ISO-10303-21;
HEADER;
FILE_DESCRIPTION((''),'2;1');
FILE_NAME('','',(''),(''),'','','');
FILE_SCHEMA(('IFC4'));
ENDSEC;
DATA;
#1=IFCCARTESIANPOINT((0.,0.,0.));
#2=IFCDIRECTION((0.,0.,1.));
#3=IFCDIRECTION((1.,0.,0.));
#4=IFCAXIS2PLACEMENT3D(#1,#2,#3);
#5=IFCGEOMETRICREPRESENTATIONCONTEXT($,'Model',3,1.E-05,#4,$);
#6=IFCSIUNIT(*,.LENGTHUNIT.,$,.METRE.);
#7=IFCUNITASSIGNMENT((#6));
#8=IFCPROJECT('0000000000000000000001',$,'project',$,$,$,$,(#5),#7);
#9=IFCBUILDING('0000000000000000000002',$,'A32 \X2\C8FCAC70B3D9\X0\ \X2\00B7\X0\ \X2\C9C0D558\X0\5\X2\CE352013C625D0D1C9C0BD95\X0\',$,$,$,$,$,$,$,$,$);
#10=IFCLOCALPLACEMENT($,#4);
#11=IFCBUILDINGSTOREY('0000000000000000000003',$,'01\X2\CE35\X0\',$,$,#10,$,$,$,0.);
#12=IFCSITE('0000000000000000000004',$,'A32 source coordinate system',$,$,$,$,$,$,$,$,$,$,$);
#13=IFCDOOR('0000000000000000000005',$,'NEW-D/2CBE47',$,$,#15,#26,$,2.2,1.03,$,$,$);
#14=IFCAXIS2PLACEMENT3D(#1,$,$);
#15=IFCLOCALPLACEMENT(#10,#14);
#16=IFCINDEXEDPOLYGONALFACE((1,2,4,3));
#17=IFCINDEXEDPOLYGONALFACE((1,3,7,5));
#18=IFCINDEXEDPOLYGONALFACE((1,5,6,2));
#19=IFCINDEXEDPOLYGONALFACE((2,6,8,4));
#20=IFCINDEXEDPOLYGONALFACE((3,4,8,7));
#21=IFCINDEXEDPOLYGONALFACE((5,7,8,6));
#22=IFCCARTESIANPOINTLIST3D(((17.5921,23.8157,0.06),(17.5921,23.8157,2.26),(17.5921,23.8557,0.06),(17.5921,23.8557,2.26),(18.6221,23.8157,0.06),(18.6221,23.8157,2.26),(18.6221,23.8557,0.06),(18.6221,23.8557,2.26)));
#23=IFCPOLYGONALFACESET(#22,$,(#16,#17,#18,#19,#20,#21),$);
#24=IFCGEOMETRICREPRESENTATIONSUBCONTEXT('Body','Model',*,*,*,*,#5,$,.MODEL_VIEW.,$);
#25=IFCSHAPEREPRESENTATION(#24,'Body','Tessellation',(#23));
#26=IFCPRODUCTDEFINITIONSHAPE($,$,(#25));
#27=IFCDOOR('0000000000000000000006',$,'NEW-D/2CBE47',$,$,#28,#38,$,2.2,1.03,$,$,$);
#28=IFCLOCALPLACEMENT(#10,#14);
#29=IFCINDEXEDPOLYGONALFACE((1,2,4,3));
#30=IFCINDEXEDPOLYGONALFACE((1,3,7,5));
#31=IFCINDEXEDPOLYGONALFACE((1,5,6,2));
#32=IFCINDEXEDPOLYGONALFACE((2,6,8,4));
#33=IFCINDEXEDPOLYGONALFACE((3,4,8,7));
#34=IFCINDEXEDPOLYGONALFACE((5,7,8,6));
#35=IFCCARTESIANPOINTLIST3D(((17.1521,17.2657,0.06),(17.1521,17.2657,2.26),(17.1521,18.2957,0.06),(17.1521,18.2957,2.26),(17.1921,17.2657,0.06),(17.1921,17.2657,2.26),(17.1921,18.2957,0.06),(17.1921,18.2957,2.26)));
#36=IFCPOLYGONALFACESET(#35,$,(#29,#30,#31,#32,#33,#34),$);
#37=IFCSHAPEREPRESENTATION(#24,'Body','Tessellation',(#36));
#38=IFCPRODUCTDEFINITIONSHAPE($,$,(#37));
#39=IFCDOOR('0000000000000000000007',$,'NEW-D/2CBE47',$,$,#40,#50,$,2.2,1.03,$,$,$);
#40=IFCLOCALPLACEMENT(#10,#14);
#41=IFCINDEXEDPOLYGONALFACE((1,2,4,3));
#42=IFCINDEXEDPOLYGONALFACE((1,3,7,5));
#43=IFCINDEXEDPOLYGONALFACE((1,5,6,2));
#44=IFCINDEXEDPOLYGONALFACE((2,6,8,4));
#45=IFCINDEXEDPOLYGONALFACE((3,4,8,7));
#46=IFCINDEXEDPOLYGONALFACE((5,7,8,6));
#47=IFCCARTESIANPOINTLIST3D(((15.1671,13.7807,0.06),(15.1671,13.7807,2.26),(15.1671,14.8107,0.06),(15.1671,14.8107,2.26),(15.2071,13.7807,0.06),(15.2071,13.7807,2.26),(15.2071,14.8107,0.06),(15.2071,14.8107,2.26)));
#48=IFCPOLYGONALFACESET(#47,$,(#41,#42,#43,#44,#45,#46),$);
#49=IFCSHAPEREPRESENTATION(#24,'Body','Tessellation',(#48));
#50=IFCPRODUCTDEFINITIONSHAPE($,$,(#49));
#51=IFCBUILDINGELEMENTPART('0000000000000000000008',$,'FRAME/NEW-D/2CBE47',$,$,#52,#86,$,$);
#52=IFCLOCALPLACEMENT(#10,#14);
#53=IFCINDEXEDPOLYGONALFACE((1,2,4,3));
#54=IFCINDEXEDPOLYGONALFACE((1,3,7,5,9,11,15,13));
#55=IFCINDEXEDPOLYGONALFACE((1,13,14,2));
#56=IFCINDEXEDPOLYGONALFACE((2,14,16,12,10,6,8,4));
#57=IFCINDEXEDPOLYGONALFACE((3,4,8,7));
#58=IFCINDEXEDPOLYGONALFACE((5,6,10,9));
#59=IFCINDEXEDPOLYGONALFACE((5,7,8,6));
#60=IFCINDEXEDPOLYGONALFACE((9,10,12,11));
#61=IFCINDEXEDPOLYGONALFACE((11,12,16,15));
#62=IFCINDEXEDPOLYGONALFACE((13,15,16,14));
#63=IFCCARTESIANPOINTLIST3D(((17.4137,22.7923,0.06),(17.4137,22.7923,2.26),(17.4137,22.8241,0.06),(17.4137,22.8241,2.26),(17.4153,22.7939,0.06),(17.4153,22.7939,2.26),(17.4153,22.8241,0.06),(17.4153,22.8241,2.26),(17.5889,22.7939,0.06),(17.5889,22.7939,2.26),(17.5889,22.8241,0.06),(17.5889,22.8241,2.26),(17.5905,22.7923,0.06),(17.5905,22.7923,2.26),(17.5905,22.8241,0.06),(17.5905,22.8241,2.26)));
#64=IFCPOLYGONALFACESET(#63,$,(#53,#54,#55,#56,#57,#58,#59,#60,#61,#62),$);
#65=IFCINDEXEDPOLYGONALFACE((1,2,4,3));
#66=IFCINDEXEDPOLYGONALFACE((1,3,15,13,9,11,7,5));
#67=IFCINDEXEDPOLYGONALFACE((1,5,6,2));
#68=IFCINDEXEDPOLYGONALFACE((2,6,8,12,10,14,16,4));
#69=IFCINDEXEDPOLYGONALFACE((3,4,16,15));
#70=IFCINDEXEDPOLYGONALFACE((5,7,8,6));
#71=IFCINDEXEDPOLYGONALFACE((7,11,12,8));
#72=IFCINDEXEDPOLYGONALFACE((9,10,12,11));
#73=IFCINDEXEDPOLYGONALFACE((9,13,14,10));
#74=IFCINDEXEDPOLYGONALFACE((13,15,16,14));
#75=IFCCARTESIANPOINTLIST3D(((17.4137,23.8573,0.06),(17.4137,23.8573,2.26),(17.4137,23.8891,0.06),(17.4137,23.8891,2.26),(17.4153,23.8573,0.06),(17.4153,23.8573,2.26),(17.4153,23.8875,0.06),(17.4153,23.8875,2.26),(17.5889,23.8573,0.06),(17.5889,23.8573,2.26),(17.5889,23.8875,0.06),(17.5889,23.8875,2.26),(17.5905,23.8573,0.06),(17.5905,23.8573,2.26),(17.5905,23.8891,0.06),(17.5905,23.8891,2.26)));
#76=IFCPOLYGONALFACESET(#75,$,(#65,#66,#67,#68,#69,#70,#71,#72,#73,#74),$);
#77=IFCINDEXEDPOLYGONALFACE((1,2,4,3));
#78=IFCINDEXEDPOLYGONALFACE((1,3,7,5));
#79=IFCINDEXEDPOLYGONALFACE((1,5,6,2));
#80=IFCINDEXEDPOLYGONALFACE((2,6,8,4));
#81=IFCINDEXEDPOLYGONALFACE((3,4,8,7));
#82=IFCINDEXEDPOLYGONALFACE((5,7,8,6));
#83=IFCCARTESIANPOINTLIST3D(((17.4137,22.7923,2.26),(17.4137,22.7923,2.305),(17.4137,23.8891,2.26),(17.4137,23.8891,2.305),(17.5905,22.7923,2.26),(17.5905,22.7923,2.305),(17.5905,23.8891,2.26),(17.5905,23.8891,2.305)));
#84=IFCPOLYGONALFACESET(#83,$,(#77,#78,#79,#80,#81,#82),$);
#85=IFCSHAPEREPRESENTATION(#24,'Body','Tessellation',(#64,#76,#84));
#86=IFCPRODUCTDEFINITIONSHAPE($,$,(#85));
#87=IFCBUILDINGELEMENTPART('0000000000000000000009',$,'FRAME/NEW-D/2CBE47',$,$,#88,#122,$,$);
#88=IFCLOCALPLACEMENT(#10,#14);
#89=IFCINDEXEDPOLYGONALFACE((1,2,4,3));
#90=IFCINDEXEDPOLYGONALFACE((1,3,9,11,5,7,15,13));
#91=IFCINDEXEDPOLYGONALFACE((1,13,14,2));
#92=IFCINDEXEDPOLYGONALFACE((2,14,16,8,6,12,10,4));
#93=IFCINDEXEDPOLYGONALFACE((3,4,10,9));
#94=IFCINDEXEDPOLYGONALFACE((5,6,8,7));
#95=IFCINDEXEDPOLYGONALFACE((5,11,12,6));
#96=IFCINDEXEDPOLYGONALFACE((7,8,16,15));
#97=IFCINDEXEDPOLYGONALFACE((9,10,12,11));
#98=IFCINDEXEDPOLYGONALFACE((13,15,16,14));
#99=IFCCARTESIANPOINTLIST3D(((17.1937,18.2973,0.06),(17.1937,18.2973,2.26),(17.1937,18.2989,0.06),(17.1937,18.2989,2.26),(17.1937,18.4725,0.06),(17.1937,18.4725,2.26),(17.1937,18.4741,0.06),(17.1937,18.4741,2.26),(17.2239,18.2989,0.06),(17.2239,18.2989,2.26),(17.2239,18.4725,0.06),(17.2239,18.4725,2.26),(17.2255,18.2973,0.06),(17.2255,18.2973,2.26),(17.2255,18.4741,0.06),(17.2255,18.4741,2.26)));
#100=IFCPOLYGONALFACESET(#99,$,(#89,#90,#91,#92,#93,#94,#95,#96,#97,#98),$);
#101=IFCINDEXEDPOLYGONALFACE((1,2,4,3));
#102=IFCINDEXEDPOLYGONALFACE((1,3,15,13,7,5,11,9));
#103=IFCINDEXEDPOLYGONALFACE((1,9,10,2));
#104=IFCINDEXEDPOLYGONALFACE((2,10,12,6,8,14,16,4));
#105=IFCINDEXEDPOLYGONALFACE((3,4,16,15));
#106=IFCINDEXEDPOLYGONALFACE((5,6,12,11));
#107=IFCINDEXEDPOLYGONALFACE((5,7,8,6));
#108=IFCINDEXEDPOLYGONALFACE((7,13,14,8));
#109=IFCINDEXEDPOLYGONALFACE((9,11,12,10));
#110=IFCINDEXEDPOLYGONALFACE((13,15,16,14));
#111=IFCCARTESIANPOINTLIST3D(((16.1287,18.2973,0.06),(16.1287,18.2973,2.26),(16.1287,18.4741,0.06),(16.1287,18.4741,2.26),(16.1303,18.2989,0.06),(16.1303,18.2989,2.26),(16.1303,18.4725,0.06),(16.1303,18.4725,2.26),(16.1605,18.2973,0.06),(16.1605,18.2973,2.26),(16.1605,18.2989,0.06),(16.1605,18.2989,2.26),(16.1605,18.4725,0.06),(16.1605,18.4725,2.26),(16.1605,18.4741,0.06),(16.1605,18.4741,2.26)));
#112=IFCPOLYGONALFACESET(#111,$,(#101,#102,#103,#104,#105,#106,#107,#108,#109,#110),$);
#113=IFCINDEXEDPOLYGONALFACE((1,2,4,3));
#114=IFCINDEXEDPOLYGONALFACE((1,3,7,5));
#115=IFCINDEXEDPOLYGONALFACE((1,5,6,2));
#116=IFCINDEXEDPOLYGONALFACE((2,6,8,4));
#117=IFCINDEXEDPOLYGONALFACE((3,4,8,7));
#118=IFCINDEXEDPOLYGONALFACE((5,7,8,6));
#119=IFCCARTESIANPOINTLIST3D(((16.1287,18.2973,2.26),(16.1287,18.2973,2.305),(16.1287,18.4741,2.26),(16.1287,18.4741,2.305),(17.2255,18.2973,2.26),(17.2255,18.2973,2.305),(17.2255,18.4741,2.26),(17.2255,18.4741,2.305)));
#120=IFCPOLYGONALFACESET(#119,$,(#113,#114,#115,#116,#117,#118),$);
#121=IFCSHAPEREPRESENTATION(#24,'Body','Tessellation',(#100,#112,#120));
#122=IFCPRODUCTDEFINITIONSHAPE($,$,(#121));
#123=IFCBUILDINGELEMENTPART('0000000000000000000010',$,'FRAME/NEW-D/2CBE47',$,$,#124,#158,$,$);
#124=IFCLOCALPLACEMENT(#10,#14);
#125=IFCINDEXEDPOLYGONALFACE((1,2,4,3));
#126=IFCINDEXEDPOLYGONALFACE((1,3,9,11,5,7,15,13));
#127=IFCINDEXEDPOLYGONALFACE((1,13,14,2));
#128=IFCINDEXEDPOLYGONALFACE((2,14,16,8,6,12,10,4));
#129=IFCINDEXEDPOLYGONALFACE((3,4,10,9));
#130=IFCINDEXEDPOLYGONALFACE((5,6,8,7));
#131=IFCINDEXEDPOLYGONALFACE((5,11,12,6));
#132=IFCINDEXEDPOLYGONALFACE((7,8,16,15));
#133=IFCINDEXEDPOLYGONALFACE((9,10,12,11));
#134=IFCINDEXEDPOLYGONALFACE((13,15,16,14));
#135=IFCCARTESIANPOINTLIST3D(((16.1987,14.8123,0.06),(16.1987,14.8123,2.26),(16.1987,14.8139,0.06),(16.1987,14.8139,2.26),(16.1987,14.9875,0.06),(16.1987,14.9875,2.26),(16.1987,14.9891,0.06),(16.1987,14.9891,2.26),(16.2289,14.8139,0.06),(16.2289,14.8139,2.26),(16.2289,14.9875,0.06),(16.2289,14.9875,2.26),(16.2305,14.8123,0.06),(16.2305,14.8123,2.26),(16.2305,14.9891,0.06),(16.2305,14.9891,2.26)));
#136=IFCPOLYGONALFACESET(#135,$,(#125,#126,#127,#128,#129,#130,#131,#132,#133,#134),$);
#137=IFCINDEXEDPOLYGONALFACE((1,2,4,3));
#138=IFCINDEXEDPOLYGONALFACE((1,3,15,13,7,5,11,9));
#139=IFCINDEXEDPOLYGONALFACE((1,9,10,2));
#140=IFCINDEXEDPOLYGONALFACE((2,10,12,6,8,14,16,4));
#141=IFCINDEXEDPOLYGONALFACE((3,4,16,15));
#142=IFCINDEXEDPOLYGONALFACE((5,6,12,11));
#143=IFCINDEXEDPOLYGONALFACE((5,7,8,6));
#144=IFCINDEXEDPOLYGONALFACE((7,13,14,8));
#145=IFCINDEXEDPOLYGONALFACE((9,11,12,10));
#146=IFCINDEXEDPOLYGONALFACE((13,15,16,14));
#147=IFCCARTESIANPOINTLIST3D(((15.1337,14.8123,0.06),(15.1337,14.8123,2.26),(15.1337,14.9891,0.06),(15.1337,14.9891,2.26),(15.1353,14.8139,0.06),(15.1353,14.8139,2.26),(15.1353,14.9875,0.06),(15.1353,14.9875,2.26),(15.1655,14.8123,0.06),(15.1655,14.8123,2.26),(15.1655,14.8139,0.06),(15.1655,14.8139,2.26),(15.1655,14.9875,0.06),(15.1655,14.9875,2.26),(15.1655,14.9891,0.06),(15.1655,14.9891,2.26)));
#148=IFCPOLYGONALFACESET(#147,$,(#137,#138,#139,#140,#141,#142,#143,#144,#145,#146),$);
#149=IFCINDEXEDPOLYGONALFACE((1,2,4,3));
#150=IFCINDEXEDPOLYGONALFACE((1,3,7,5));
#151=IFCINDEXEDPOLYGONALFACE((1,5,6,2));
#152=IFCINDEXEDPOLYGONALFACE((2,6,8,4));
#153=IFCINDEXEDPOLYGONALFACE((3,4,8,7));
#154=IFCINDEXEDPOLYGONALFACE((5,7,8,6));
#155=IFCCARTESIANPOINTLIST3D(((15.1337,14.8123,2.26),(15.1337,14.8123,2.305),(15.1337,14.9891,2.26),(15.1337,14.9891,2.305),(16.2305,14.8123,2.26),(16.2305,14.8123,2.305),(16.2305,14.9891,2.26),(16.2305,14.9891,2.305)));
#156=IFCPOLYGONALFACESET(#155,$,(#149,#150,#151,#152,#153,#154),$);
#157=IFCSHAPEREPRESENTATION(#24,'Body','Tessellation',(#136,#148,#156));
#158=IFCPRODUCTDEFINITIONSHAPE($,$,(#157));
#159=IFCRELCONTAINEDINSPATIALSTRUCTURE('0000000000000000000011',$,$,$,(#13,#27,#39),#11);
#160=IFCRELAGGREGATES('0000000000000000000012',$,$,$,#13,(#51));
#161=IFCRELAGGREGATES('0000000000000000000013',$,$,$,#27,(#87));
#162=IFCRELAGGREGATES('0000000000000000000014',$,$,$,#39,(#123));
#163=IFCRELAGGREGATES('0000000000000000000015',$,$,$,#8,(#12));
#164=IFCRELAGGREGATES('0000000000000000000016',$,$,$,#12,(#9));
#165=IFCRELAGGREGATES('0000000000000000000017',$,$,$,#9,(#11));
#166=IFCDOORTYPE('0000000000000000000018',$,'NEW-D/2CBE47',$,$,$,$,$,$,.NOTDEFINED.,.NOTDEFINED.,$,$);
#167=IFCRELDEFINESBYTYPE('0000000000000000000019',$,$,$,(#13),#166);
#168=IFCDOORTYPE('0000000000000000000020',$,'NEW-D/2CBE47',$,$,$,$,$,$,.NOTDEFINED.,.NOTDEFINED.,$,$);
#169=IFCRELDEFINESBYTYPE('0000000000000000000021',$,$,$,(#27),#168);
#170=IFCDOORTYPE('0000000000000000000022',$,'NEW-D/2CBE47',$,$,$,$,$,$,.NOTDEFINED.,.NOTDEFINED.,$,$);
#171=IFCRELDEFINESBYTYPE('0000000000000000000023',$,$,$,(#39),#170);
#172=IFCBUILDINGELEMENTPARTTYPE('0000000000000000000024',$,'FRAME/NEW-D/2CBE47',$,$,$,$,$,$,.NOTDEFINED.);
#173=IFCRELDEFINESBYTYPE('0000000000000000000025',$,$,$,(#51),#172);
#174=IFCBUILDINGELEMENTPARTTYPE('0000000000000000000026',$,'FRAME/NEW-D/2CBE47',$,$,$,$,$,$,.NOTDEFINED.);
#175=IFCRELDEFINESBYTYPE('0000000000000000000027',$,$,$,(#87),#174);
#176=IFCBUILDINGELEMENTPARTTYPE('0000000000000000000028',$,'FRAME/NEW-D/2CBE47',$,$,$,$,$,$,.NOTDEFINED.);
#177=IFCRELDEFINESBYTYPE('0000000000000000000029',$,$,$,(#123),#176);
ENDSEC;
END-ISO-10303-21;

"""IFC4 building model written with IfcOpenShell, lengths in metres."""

from ifc_helpers import new_model, si_unit, frame, origin, origin_with_axes, place, context, subcontext, project, spatial, polyline, outline, extrude, source, transform, mapped, type_object, type_shapes, element, aggregate, save


model = new_model("IFC4")

# Units and contexts
model_context = context("Model", 3, precision=1e-05, world=origin_with_axes())
body_context = subcontext(model_context, "Body", "Model", "MODEL_VIEW")
ifc_project = project(units=[si_unit("LENGTHUNIT", "METRE")], contexts=[model_context])

# Site, building, storey
site = spatial("IfcSite", under=ifc_project, Name="A32 source coordinate system")
building = spatial("IfcBuilding", under=site, Name="A32 주거동 · 지하5층–옥탑지붕")
storey_placement = place(None, origin_with_axes())
storey = spatial("IfcBuildingStorey", under=building, at=storey_placement, Name="01층", Elevation=0.0)

# Doors
door_type_1 = type_object("IfcDoorType", Name="NEW-D/2CBE47", OperationType="NOTDEFINED", PredefinedType="NOTDEFINED")
shared_shape_1 = source(origin(), body_context, "Body", "SweptSolid", [
    extrude(outline(polyline([(18.6221, 23.8157), (17.5921, 23.8157), (17.5921, 23.8557), (18.6221, 23.8557), (18.6221, 23.8157)])), frame((0.0, 0.0, 0.06)), (0.0, 0.0, 1.0), 2.2),
])
type_shapes(door_type_1, [shared_shape_1])
door_1_placement = place(storey_placement, origin_with_axes())
door_1 = element("IfcDoor", 1, at=door_1_placement, inside=storey, type_object=door_type_1, Name="NEW-D/2CBE47", OverallHeight=2.2, OverallWidth=1.03, context=body_context, shape_type="MappedRepresentation", body=[
    mapped(shared_shape_1, transform((0.0, 0.0, 0.0), scale=1.0)),
])
door_type_2 = type_object("IfcDoorType", Name="NEW-D/2CBE47", OperationType="NOTDEFINED", PredefinedType="NOTDEFINED")
shared_shape_2 = source(origin(), body_context, "Body", "SweptSolid", [
    extrude(outline(polyline([(17.1521, 17.2657), (17.1521, 18.2957), (17.1921, 18.2957), (17.1921, 17.2657), (17.1521, 17.2657)])), frame((0.0, 0.0, 0.06)), (0.0, 0.0, 1.0), 2.2),
])
type_shapes(door_type_2, [shared_shape_2])
door_2_placement = place(storey_placement, origin_with_axes())
door_2 = element("IfcDoor", 2, at=door_2_placement, inside=storey, type_object=door_type_2, Name="NEW-D/2CBE47", OverallHeight=2.2, OverallWidth=1.03, context=body_context, shape_type="MappedRepresentation", body=[
    mapped(shared_shape_2, transform((0.0, 0.0, 0.0), scale=1.0)),
])
door_type_3 = type_object("IfcDoorType", Name="NEW-D/2CBE47", OperationType="NOTDEFINED", PredefinedType="NOTDEFINED")
shared_shape_3 = source(origin(), body_context, "Body", "SweptSolid", [
    extrude(outline(polyline([(15.1671, 14.8107), (15.2071, 14.8107), (15.2071, 13.7807), (15.1671, 13.7807), (15.1671, 14.8107)])), frame((0.0, 0.0, 0.06)), (0.0, 0.0, 1.0), 2.2),
])
type_shapes(door_type_3, [shared_shape_3])
door_3_placement = place(storey_placement, origin_with_axes())
door_3 = element("IfcDoor", 3, at=door_3_placement, inside=storey, type_object=door_type_3, Name="NEW-D/2CBE47", OverallHeight=2.2, OverallWidth=1.03, context=body_context, shape_type="MappedRepresentation", body=[
    mapped(shared_shape_3, transform((0.0, 0.0, 0.0), scale=1.0)),
])

# Building element parts
building_element_part_type_1 = type_object("IfcBuildingElementPartType", Name="FRAME/NEW-D/2CBE47", PredefinedType="NOTDEFINED")
shared_shape_4 = source(origin(), body_context, "Body", "SweptSolid", [
    extrude(outline(polyline([(17.4137, 22.7923), (17.4137, 22.8241), (17.4153, 22.8241), (17.4153, 22.7939), (17.5889, 22.7939), (17.5889, 22.8241), (17.5905, 22.8241), (17.5905, 22.7923), (17.4137, 22.7923)])), frame((0.0, 0.0, 0.06)), (0.0, 0.0, 1.0), 2.2),
    extrude(outline(polyline([(17.5889, 23.8875), (17.4153, 23.8875), (17.4153, 23.8573), (17.4137, 23.8573), (17.4137, 23.8891), (17.5905, 23.8891), (17.5905, 23.8573), (17.5889, 23.8573), (17.5889, 23.8875)])), frame((0.0, 0.0, 0.06)), (0.0, 0.0, 1.0), 2.2),
    extrude(outline(polyline([(17.5905, 22.7923), (17.5905, 23.8891), (17.4137, 23.8891), (17.4137, 22.7923), (17.5905, 22.7923)])), frame((0.0, 0.0, 2.26)), (0.0, 0.0, 1.0), 0.045),
])
type_shapes(building_element_part_type_1, [shared_shape_4])
building_element_part_1_placement = place(door_1_placement, origin_with_axes())
building_element_part_1 = element("IfcBuildingElementPart", 4, at=building_element_part_1_placement, type_object=building_element_part_type_1, Name="FRAME/NEW-D/2CBE47", context=body_context, shape_type="MappedRepresentation", body=[
    mapped(shared_shape_4, transform((0.0, 0.0, 0.0), scale=1.0)),
])
aggregate(door_1, [building_element_part_1])
building_element_part_type_2 = type_object("IfcBuildingElementPartType", Name="FRAME/NEW-D/2CBE47", PredefinedType="NOTDEFINED")
shared_shape_5 = source(origin(), body_context, "Body", "SweptSolid", [
    extrude(outline(polyline([(17.2239, 18.2989), (17.2239, 18.4725), (17.1937, 18.4725), (17.1937, 18.4741), (17.2255, 18.4741), (17.2255, 18.2973), (17.1937, 18.2973), (17.1937, 18.2989), (17.2239, 18.2989)])), frame((0.0, 0.0, 0.06)), (0.0, 0.0, 1.0), 2.2),
    extrude(outline(polyline([(16.1287, 18.4741), (16.1605, 18.4741), (16.1605, 18.4725), (16.1303, 18.4725), (16.1303, 18.2989), (16.1605, 18.2989), (16.1605, 18.2973), (16.1287, 18.2973), (16.1287, 18.4741)])), frame((0.0, 0.0, 0.06)), (0.0, 0.0, 1.0), 2.2),
    extrude(outline(polyline([(17.2255, 18.2973), (17.2255, 18.4741), (16.1287, 18.4741), (16.1287, 18.2973), (17.2255, 18.2973)])), frame((0.0, 0.0, 2.26)), (0.0, 0.0, 1.0), 0.045),
])
type_shapes(building_element_part_type_2, [shared_shape_5])
building_element_part_2_placement = place(door_2_placement, origin_with_axes())
building_element_part_2 = element("IfcBuildingElementPart", 5, at=building_element_part_2_placement, type_object=building_element_part_type_2, Name="FRAME/NEW-D/2CBE47", context=body_context, shape_type="MappedRepresentation", body=[
    mapped(shared_shape_5, transform((0.0, 0.0, 0.0), scale=1.0)),
])
aggregate(door_2, [building_element_part_2])
building_element_part_type_3 = type_object("IfcBuildingElementPartType", Name="FRAME/NEW-D/2CBE47", PredefinedType="NOTDEFINED")
shared_shape_6 = source(origin(), body_context, "Body", "SweptSolid", [
    extrude(outline(polyline([(16.2289, 14.8139), (16.2289, 14.9875), (16.1987, 14.9875), (16.1987, 14.9891), (16.2305, 14.9891), (16.2305, 14.8123), (16.1987, 14.8123), (16.1987, 14.8139), (16.2289, 14.8139)])), frame((0.0, 0.0, 0.06)), (0.0, 0.0, 1.0), 2.2),
    extrude(outline(polyline([(15.1337, 14.9891), (15.1655, 14.9891), (15.1655, 14.9875), (15.1353, 14.9875), (15.1353, 14.8139), (15.1655, 14.8139), (15.1655, 14.8123), (15.1337, 14.8123), (15.1337, 14.9891)])), frame((0.0, 0.0, 0.06)), (0.0, 0.0, 1.0), 2.2),
    extrude(outline(polyline([(16.2305, 14.8123), (16.2305, 14.9891), (15.1337, 14.9891), (15.1337, 14.8123), (16.2305, 14.8123)])), frame((0.0, 0.0, 2.26)), (0.0, 0.0, 1.0), 0.045),
])
type_shapes(building_element_part_type_3, [shared_shape_6])
building_element_part_3_placement = place(door_3_placement, origin_with_axes())
building_element_part_3 = element("IfcBuildingElementPart", 6, at=building_element_part_3_placement, type_object=building_element_part_type_3, Name="FRAME/NEW-D/2CBE47", context=body_context, shape_type="MappedRepresentation", body=[
    mapped(shared_shape_6, transform((0.0, 0.0, 0.0), scale=1.0)),
])
aggregate(door_3, [building_element_part_3])

save(model, "model.ifc")
